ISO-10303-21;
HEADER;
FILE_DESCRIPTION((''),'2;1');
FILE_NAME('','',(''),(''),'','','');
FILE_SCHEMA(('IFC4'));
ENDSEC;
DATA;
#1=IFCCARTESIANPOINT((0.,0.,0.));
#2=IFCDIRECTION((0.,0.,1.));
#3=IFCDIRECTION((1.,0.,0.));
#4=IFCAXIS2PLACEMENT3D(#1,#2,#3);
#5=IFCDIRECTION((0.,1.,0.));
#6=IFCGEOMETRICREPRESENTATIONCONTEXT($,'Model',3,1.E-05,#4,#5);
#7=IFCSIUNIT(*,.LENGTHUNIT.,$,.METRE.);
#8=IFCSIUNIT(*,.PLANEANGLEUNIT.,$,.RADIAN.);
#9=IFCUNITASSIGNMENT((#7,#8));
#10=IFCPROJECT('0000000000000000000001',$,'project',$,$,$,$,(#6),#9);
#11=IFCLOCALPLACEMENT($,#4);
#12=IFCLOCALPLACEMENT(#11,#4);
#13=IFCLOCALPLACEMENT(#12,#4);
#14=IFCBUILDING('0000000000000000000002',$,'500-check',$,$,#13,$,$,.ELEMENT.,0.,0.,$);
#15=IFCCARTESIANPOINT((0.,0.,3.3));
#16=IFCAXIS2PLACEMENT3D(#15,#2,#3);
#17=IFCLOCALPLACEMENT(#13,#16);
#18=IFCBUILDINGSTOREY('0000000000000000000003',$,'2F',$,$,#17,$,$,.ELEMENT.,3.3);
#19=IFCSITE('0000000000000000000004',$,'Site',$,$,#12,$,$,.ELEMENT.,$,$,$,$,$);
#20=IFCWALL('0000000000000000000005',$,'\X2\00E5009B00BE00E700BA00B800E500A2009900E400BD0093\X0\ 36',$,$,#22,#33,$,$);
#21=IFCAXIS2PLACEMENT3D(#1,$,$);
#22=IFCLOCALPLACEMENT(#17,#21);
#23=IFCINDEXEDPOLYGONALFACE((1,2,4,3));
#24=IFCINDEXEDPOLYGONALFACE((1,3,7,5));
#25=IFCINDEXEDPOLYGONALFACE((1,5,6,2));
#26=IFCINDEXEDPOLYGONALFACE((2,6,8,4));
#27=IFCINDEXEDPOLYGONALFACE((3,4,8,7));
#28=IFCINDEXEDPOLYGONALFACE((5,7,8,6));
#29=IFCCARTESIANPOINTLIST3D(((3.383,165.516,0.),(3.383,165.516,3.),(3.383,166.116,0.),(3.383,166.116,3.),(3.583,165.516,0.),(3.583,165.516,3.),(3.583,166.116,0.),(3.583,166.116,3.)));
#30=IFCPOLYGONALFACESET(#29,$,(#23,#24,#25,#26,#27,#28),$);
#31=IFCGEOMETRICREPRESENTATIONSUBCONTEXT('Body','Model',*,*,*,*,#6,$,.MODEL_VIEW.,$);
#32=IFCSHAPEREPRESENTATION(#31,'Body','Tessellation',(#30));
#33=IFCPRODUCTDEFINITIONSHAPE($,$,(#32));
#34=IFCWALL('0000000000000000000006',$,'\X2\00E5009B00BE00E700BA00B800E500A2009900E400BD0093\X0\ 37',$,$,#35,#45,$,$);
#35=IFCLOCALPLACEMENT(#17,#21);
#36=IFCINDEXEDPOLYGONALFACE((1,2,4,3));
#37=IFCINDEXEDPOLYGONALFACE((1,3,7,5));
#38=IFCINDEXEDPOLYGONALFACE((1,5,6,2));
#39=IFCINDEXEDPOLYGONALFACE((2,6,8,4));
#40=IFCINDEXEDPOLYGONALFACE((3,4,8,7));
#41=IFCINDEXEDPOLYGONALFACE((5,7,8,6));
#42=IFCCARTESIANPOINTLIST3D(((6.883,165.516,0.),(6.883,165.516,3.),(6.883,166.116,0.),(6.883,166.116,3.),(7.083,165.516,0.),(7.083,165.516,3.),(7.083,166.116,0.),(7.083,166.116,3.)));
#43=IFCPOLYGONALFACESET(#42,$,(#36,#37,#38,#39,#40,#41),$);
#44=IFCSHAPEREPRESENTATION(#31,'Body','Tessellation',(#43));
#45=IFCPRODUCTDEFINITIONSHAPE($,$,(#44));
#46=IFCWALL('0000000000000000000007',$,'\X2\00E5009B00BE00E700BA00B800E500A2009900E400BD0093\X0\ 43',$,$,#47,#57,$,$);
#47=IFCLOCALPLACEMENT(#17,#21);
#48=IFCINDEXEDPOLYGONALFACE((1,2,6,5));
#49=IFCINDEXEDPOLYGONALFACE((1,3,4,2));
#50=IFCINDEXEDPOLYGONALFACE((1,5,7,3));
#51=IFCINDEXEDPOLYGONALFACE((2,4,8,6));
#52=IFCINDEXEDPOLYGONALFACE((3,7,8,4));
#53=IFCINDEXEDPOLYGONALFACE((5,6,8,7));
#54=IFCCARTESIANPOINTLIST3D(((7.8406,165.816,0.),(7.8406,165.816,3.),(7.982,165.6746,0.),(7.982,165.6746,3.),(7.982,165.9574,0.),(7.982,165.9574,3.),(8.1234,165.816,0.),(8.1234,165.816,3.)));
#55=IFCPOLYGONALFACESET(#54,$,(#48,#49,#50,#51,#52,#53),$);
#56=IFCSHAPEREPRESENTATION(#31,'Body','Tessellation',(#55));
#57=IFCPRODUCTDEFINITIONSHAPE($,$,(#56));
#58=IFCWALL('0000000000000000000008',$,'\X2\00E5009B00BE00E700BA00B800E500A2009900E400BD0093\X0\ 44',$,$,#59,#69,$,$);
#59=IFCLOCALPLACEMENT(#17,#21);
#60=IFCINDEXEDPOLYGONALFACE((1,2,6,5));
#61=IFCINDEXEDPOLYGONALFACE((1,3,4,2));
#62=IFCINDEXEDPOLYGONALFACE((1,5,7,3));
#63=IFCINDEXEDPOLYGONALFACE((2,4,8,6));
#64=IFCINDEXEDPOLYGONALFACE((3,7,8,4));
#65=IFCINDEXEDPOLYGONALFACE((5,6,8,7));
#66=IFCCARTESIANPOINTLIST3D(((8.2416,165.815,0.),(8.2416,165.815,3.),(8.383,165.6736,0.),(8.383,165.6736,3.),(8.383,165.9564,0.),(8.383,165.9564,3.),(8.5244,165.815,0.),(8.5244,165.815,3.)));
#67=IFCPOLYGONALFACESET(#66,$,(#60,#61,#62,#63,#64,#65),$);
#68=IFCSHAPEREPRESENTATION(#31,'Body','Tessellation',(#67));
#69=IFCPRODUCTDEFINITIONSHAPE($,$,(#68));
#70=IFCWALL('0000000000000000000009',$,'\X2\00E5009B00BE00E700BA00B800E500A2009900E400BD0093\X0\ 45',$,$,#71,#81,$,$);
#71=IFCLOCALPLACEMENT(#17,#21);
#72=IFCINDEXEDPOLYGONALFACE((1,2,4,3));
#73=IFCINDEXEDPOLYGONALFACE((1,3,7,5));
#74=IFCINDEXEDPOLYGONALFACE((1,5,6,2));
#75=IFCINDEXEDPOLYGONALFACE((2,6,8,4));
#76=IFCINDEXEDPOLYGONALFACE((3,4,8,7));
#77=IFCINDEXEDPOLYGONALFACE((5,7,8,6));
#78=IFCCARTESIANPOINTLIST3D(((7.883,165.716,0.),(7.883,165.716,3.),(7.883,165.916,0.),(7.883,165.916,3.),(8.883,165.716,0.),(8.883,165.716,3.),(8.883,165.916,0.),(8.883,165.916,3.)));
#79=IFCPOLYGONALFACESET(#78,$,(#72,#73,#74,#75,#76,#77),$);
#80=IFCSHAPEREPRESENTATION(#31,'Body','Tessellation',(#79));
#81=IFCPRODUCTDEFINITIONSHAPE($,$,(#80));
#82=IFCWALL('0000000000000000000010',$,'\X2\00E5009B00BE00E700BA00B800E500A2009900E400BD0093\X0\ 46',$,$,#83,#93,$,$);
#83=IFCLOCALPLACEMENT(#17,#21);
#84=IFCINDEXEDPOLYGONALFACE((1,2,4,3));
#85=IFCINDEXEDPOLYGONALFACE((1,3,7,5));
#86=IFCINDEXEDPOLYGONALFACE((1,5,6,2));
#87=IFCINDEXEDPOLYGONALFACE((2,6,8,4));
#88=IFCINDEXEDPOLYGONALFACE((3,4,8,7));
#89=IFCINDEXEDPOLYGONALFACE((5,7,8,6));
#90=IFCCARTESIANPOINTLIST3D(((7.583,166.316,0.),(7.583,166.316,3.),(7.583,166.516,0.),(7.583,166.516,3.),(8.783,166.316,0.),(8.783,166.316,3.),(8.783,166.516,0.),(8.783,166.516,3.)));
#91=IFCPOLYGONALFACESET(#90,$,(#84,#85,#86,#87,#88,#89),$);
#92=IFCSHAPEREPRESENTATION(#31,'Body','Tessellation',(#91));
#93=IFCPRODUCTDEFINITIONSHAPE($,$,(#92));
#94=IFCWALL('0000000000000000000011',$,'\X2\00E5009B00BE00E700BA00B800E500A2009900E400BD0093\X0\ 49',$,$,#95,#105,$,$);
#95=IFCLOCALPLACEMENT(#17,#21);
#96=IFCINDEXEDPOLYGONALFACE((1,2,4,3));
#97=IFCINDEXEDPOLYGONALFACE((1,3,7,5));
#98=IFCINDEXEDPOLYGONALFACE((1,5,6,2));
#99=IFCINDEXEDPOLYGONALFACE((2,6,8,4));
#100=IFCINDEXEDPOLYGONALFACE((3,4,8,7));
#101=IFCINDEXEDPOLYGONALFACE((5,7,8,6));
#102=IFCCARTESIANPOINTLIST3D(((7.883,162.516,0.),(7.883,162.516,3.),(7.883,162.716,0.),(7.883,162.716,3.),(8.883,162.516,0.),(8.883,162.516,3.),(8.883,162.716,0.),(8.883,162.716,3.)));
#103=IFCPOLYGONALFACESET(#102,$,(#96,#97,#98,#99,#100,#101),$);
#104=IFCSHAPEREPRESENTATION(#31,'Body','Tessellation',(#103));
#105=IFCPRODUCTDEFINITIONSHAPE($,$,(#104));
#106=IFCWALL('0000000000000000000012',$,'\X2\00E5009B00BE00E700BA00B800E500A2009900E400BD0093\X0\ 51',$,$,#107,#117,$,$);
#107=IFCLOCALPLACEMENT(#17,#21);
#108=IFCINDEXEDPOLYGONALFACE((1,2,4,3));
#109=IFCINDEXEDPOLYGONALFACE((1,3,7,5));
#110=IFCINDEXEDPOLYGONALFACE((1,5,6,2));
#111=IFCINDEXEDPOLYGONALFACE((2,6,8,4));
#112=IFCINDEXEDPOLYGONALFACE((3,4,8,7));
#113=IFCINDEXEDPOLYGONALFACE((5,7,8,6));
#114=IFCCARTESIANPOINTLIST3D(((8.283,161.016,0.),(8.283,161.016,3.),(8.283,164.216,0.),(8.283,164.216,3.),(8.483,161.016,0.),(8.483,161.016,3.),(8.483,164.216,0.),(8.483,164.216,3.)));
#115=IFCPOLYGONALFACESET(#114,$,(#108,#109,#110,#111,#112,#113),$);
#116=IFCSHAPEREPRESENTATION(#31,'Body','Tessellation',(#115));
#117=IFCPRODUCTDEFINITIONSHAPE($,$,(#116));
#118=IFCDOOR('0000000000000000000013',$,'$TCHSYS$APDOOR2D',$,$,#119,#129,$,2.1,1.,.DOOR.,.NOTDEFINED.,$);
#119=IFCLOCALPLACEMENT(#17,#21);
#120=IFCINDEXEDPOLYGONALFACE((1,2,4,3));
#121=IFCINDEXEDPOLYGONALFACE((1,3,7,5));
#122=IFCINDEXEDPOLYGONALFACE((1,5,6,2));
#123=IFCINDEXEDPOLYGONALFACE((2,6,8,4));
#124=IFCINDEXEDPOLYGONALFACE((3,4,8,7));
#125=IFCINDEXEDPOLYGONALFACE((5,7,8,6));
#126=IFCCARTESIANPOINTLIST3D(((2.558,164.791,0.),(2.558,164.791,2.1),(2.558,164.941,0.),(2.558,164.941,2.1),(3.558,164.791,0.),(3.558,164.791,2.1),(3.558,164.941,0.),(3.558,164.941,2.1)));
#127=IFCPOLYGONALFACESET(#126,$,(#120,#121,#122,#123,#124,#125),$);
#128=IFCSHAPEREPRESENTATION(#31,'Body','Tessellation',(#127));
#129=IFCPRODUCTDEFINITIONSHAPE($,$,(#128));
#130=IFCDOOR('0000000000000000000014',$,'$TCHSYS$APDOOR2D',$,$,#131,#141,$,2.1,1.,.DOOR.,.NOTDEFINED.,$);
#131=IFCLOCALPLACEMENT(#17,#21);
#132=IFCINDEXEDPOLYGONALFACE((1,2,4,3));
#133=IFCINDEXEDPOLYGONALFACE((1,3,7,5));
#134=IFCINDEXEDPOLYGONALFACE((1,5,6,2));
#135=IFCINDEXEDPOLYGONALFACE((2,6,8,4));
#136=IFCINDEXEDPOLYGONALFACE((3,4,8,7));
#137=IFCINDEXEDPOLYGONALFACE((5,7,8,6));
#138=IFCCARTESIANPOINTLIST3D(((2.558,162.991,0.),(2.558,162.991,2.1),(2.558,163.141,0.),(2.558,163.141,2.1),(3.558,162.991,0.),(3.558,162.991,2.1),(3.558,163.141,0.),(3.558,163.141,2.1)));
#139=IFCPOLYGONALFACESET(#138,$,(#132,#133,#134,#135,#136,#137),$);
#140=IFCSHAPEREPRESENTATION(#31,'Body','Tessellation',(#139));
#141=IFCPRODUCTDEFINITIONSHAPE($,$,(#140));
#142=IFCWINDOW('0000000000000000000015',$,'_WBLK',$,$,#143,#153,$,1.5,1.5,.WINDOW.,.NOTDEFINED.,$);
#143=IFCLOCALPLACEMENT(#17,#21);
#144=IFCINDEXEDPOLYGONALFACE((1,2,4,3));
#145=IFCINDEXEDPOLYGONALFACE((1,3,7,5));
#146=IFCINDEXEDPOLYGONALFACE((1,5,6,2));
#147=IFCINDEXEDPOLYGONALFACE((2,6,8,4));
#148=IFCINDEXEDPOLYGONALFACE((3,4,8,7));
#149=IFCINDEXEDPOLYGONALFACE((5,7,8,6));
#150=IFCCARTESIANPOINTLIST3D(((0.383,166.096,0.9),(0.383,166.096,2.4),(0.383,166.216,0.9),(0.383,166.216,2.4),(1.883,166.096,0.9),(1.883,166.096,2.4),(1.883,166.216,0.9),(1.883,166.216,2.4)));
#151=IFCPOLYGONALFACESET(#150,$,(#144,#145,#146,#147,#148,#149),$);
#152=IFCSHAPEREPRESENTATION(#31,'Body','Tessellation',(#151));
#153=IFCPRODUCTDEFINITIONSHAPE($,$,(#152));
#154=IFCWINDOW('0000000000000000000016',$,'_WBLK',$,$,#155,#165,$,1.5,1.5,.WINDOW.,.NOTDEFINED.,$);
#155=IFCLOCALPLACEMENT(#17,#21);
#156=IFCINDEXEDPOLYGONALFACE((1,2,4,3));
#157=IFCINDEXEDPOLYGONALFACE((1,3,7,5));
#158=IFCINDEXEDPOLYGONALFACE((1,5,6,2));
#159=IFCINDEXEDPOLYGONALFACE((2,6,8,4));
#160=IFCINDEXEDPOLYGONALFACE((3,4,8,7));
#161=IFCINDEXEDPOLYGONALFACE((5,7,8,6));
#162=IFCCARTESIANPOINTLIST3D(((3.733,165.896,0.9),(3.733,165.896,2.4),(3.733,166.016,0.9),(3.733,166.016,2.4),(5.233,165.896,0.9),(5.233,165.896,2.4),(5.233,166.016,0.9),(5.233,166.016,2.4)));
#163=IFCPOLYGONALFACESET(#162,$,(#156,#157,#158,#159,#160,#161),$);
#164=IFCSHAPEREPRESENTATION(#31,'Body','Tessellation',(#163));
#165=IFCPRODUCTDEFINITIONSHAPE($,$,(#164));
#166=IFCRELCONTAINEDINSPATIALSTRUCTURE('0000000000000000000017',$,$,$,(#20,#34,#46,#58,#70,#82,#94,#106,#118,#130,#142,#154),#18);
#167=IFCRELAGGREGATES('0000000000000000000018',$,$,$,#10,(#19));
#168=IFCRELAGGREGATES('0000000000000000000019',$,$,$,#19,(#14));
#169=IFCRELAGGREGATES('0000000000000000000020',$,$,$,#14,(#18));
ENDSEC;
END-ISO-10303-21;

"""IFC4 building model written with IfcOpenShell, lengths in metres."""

from ifc_helpers import new_model, si_unit, direction, frame, frame_2d, origin_with_axes, place, context, subcontext, project, spatial, rectangle, extrude, element, save


model = new_model("IFC4")

# Units and contexts
model_context = context("Model", 3, precision=1e-05, world=origin_with_axes(), true_north=direction((0.0, 1.0, 0.0)))
body_context = subcontext(model_context, "Body", "Model", "MODEL_VIEW")
ifc_project = project(units=[si_unit("LENGTHUNIT", "METRE"), si_unit("PLANEANGLEUNIT", "RADIAN")], contexts=[model_context])

# Site, building, storey
placement = place(None, origin_with_axes())
site_placement = place(placement, origin_with_axes())
site = spatial("IfcSite", under=ifc_project, at=site_placement, Name="Site", CompositionType="ELEMENT")
building_placement = place(site_placement, origin_with_axes())
building = spatial("IfcBuilding", under=site, at=building_placement, Name="500-check", CompositionType="ELEMENT", ElevationOfRefHeight=0.0, ElevationOfTerrain=0.0)
storey_placement = place(building_placement, frame((0.0, 0.0, 3.3), z_axis=(0.0, 0.0, 1.0), x_axis=(1.0, 0.0, 0.0)))
storey = spatial("IfcBuildingStorey", under=building, at=storey_placement, Name="2F", CompositionType="ELEMENT", Elevation=3.3)

# Walls
for number, where, z_axis, x_axis, name in (
    (1, (3.483, 165.816, 0.0), (0.0, 0.0, 1.0), (0.0, 1.0, 0.0), "å\u009b¾çº¸å¢\u0099ä½\u0093 36"),
    (2, (6.983, 165.816, 0.0), (0.0, 0.0, 1.0), (0.0, 1.0, 0.0), "å\u009b¾çº¸å¢\u0099ä½\u0093 37"),
):
    element("IfcWall", number, at=place(storey_placement, frame(where, z_axis=z_axis, x_axis=x_axis)), inside=storey, Name=name, context=body_context, shape_type="SweptSolid", body=[
        extrude(rectangle(XDim=0.6, YDim=0.2, at=frame_2d((0.0, 0.0), x_axis=(1.0, 0.0, 0.0))), frame((0.0, 0.0, 0.0), z_axis=(0.0, 0.0, 1.0)), (0.0, 0.0, 1.0), 3.0),
    ])
for number, where, z_axis, x_axis, name in (
    (3, (7.982, 165.816, 0.0), (0.0, 0.0, 1.0), (0.707107, -0.707107, 0.0), "å\u009b¾çº¸å¢\u0099ä½\u0093 43"),
    (4, (8.383, 165.815, 0.0), (0.0, 0.0, 1.0), (0.707107, 0.707107, 0.0), "å\u009b¾çº¸å¢\u0099ä½\u0093 44"),
):
    element("IfcWall", number, at=place(storey_placement, frame(where, z_axis=z_axis, x_axis=x_axis)), inside=storey, Name=name, context=body_context, shape_type="SweptSolid", body=[
        extrude(rectangle(XDim=0.2, YDim=0.2, at=frame_2d((0.0, 0.0), x_axis=(1.0, 0.0, 0.0))), frame((0.0, 0.0, 0.0), z_axis=(0.0, 0.0, 1.0)), (0.0, 0.0, 1.0), 3.0),
    ])
wall_1_placement = place(storey_placement, frame((8.383, 165.816, 0.0), z_axis=(0.0, 0.0, 1.0), x_axis=(1.0, 0.0, 0.0)))
element("IfcWall", 5, at=wall_1_placement, inside=storey, Name="å\u009b¾çº¸å¢\u0099ä½\u0093 45", context=body_context, shape_type="SweptSolid", body=[
    extrude(rectangle(XDim=1.0, YDim=0.2, at=frame_2d((0.0, 0.0), x_axis=(1.0, 0.0, 0.0))), frame((0.0, 0.0, 0.0), z_axis=(0.0, 0.0, 1.0)), (0.0, 0.0, 1.0), 3.0),
])
wall_2_placement = place(storey_placement, frame((8.183, 166.416, 0.0), z_axis=(0.0, 0.0, 1.0), x_axis=(1.0, 0.0, 0.0)))
element("IfcWall", 6, at=wall_2_placement, inside=storey, Name="å\u009b¾çº¸å¢\u0099ä½\u0093 46", context=body_context, shape_type="SweptSolid", body=[
    extrude(rectangle(XDim=1.2, YDim=0.2, at=frame_2d((0.0, 0.0), x_axis=(1.0, 0.0, 0.0))), frame((0.0, 0.0, 0.0), z_axis=(0.0, 0.0, 1.0)), (0.0, 0.0, 1.0), 3.0),
])
wall_3_placement = place(storey_placement, frame((8.383, 162.616, 0.0), z_axis=(0.0, 0.0, 1.0), x_axis=(1.0, 0.0, 0.0)))
element("IfcWall", 7, at=wall_3_placement, inside=storey, Name="å\u009b¾çº¸å¢\u0099ä½\u0093 49", context=body_context, shape_type="SweptSolid", body=[
    extrude(rectangle(XDim=1.0, YDim=0.2, at=frame_2d((0.0, 0.0), x_axis=(1.0, 0.0, 0.0))), frame((0.0, 0.0, 0.0), z_axis=(0.0, 0.0, 1.0)), (0.0, 0.0, 1.0), 3.0),
])
wall_4_placement = place(storey_placement, frame((8.383, 162.616, 0.0), z_axis=(0.0, 0.0, 1.0), x_axis=(0.0, 1.0, 0.0)))
element("IfcWall", 8, at=wall_4_placement, inside=storey, Name="å\u009b¾çº¸å¢\u0099ä½\u0093 51", context=body_context, shape_type="SweptSolid", body=[
    extrude(rectangle(XDim=3.2, YDim=0.2, at=frame_2d((0.0, 0.0), x_axis=(1.0, 0.0, 0.0))), frame((0.0, 0.0, 0.0), z_axis=(0.0, 0.0, 1.0)), (0.0, 0.0, 1.0), 3.0),
])

# Doors
for number, where, z_axis, x_axis, name in (
    (9, (3.058, 164.866, 0.0), (0.0, 0.0, 1.0), (1.0, 0.0, 0.0), "$TCHSYS$APDOOR2D"),
    (10, (3.058, 163.066, 0.0), (0.0, 0.0, 1.0), (1.0, 0.0, 0.0), "$TCHSYS$APDOOR2D"),
):
    element("IfcDoor", number, at=place(storey_placement, frame(where, z_axis=z_axis, x_axis=x_axis)), inside=storey, Name=name, OperationType="NOTDEFINED", OverallHeight=2.1, OverallWidth=1.0, PredefinedType="DOOR", context=body_context, shape_type="SweptSolid", body=[
        extrude(rectangle(XDim=1.0, YDim=0.15, at=frame_2d((0.0, 0.0), x_axis=(1.0, 0.0, 0.0))), frame((0.0, 0.0, 0.0), z_axis=(0.0, 0.0, 1.0)), (0.0, 0.0, 1.0), 2.1),
    ])

# Windows
for number, where, z_axis, x_axis, name in (
    (11, (1.133, 166.156, 0.9), (0.0, 0.0, 1.0), (1.0, 0.0, 0.0), "_WBLK"),
    (12, (4.483, 165.956, 0.9), (0.0, 0.0, 1.0), (1.0, 0.0, 0.0), "_WBLK"),
):
    element("IfcWindow", number, at=place(storey_placement, frame(where, z_axis=z_axis, x_axis=x_axis)), inside=storey, Name=name, OverallHeight=1.5, OverallWidth=1.5, PartitioningType="NOTDEFINED", PredefinedType="WINDOW", context=body_context, shape_type="SweptSolid", body=[
        extrude(rectangle(XDim=1.5, YDim=0.12, at=frame_2d((0.0, 0.0), x_axis=(1.0, 0.0, 0.0))), frame((0.0, 0.0, 0.0), z_axis=(0.0, 0.0, 1.0)), (0.0, 0.0, 1.0), 1.5),
    ])

save(model, "model.ifc")
